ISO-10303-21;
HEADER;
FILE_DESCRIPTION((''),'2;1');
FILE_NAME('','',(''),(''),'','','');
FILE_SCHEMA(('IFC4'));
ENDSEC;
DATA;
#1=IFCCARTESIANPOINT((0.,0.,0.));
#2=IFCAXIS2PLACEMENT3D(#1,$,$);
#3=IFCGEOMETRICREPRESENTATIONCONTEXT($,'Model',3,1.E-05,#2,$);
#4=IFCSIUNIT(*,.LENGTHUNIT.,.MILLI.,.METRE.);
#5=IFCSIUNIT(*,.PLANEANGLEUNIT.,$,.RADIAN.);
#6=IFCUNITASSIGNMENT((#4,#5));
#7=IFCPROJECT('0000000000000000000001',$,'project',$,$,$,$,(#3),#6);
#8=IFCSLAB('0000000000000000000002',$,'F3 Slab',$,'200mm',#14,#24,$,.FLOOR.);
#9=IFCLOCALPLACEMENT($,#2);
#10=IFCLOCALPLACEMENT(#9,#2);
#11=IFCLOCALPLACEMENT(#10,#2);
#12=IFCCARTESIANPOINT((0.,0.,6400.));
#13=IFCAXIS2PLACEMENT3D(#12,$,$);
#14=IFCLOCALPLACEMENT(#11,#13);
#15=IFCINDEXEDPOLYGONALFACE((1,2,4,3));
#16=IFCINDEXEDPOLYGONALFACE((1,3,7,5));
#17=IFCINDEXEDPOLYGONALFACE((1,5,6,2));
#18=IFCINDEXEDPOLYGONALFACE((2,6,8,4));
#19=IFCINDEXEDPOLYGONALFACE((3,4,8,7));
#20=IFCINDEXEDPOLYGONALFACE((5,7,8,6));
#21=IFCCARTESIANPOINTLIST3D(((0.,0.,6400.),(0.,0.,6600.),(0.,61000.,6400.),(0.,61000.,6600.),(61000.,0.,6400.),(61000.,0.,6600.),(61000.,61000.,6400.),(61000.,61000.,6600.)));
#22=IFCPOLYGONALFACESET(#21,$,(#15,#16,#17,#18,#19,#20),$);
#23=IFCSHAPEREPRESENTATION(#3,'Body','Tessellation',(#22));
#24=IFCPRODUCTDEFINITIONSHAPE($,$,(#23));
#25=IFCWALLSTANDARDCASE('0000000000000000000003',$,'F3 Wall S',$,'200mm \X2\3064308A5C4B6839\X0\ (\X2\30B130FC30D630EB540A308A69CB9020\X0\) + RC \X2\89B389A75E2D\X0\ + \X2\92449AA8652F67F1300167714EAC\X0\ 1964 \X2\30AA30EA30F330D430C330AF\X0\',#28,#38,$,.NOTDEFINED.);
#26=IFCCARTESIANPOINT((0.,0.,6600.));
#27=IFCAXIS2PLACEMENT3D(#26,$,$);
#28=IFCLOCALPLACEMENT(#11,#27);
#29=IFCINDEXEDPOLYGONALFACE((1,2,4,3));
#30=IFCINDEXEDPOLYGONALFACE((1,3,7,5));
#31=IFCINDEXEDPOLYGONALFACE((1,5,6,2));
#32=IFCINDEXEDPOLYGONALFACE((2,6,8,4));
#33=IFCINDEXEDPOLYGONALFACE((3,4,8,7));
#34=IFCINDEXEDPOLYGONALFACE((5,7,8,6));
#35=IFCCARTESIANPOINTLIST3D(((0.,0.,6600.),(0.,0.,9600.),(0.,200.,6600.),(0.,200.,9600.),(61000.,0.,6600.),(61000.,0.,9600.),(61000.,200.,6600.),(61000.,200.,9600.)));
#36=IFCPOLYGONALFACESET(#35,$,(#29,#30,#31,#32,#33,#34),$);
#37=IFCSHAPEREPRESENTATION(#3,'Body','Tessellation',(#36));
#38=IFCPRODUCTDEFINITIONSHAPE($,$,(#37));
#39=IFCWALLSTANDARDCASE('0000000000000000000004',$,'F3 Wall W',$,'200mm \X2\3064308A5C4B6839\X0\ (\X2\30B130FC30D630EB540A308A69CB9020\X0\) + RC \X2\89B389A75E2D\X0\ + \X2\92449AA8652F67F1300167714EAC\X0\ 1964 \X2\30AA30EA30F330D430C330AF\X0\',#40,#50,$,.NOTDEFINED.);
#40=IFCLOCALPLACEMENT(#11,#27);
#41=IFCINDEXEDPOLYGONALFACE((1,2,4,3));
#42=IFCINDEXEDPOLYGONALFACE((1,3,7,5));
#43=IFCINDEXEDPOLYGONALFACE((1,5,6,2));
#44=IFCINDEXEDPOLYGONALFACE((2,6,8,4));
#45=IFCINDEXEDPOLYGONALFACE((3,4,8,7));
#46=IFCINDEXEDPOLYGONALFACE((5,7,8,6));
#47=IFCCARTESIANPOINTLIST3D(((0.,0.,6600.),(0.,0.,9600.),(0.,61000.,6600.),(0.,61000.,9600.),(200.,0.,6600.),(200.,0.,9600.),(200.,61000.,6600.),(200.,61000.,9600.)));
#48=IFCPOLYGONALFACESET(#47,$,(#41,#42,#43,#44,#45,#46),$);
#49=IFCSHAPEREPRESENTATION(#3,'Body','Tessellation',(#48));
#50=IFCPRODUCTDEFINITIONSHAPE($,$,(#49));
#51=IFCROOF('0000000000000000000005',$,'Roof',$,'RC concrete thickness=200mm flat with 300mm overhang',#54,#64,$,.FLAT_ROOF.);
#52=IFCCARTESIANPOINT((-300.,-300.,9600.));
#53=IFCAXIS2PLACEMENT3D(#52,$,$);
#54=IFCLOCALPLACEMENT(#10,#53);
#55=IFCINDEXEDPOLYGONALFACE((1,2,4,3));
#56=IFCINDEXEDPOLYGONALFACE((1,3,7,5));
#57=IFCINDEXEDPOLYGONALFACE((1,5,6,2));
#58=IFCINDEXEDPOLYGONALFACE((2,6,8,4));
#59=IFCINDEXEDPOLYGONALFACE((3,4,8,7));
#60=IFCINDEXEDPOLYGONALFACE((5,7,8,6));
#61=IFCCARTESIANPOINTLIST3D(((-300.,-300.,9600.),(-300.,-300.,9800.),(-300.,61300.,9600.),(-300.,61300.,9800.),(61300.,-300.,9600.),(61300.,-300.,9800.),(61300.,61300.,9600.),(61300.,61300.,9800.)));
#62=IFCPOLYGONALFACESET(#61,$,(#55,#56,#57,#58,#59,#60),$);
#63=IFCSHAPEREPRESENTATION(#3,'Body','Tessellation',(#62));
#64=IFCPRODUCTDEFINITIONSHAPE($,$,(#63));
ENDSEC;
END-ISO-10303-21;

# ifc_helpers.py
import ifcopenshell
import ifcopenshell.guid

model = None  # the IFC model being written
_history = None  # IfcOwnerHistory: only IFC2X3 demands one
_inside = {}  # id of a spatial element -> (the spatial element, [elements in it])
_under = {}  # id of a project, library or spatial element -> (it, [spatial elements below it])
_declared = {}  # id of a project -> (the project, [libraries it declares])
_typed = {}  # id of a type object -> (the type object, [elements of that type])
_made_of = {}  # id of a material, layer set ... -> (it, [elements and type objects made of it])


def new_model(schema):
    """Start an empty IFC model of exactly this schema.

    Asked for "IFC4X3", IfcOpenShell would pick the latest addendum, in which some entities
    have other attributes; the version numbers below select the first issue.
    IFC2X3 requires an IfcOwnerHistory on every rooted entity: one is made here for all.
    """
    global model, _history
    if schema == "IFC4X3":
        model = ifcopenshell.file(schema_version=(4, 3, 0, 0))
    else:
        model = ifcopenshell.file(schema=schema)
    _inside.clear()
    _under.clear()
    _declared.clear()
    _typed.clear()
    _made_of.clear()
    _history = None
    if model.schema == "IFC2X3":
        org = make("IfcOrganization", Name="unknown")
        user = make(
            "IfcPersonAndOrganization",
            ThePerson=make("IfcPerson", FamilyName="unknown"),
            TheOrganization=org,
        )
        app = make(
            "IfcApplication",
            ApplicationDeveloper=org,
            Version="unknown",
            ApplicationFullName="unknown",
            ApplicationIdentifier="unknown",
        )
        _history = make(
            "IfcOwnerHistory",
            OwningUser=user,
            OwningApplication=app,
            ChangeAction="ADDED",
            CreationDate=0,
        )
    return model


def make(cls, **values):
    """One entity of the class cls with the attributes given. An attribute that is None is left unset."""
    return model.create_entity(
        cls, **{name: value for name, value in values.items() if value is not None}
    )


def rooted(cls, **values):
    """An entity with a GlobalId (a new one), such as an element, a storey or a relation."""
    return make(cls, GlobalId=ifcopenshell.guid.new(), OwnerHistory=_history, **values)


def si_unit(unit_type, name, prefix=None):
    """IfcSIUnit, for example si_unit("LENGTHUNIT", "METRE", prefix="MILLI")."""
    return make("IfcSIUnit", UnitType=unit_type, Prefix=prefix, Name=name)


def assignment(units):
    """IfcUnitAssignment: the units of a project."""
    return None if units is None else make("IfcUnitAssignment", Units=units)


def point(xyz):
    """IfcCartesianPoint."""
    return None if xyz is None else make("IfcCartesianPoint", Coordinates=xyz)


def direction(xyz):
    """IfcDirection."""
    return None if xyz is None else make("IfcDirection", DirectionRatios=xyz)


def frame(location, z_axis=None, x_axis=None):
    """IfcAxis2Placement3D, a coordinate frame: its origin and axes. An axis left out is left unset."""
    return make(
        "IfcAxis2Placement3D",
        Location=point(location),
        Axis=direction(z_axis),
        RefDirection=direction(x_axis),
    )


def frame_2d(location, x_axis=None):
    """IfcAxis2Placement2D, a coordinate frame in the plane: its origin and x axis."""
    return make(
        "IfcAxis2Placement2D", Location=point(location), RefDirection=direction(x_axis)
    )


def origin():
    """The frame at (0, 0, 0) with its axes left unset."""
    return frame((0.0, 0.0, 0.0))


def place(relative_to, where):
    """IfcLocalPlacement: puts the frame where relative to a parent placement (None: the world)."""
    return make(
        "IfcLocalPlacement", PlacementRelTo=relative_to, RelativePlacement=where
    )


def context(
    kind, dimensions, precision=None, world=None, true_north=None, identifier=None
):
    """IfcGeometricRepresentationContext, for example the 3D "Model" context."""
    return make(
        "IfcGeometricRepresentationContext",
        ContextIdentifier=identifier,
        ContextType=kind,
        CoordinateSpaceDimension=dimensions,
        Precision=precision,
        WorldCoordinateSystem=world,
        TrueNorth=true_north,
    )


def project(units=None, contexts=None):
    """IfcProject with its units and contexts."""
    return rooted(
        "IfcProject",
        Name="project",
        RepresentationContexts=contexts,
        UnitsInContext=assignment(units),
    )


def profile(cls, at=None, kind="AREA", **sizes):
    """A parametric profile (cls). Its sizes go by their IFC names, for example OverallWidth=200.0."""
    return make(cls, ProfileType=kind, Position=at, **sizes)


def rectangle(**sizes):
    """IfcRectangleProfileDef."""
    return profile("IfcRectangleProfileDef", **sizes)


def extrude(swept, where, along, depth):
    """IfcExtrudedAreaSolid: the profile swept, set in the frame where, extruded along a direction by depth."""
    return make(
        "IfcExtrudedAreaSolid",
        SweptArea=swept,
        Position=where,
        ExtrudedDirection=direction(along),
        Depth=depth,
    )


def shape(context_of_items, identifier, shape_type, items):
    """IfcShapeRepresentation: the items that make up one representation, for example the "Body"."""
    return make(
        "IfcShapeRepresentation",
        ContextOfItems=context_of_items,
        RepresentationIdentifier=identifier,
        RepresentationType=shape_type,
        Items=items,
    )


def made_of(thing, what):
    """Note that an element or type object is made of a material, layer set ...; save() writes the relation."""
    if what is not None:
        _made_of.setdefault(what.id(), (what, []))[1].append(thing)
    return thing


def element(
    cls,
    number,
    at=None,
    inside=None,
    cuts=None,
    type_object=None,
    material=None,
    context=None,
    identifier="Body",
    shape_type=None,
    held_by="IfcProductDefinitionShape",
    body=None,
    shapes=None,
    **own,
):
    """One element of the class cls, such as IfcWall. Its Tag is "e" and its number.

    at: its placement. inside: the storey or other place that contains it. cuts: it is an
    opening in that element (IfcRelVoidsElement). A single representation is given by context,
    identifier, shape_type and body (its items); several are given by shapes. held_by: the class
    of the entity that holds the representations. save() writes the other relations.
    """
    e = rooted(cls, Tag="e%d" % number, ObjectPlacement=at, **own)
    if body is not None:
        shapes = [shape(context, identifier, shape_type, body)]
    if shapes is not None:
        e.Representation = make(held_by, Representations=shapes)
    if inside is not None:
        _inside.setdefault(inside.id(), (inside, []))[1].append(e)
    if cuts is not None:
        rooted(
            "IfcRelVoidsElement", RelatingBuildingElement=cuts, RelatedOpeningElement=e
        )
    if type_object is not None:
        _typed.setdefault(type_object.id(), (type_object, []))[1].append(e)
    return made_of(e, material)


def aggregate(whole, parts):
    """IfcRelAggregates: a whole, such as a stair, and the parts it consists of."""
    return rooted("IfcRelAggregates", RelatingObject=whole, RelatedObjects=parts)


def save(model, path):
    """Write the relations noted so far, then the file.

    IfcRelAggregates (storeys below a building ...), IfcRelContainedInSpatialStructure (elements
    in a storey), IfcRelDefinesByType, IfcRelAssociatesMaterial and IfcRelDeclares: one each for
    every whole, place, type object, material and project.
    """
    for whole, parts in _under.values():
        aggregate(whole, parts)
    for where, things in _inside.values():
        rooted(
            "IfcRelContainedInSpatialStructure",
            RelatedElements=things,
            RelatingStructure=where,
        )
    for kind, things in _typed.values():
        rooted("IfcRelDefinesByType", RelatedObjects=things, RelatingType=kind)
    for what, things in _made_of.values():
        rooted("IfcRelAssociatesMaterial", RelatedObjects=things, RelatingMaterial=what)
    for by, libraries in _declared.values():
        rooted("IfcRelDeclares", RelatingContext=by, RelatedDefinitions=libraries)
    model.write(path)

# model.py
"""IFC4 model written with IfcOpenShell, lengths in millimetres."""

from ifc_helpers import new_model, si_unit, frame, frame_2d, origin, place, context, project, rectangle, extrude, element, save


model = new_model("IFC4")

# Units and contexts
model_context = context("Model", 3, precision=1e-05, world=origin())
ifc_project = project(units=[si_unit("LENGTHUNIT", "METRE", prefix="MILLI"), si_unit("PLANEANGLEUNIT", "RADIAN")], contexts=[model_context])

# Slab
placement_1 = place(None, origin())
placement_2 = place(placement_1, origin())
placement_3 = place(placement_2, origin())
slab_placement = place(placement_3, frame((0.0, 0.0, 6400.0)))
element("IfcSlab", 1, at=slab_placement, Name="F3 Slab", ObjectType="200mm", PredefinedType="FLOOR", context=model_context, shape_type="SweptSolid", body=[
    extrude(rectangle(XDim=61000.0, YDim=61000.0, at=frame_2d((30500.0, 30500.0))), frame((0.0, 0.0, 6400.0)), (0.0, 0.0, 1.0), 200.0),
])

# Walls
wall_1_placement = place(placement_3, frame((0.0, 0.0, 6600.0)))
element("IfcWallStandardCase", 2, at=wall_1_placement, Name="F3 Wall S", ObjectType="200mm つり屋根 (ケーブル吊り構造) + RC 観覧席 + 鉄骨支柱、東京 1964 オリンピック", PredefinedType="NOTDEFINED", context=model_context, shape_type="SweptSolid", body=[
    extrude(rectangle(XDim=61000.0, YDim=200.0, at=frame_2d((30500.0, 100.0))), frame((0.0, 0.0, 6600.0)), (0.0, 0.0, 1.0), 3000.0),
])
wall_2_placement = place(placement_3, frame((0.0, 0.0, 6600.0)))
element("IfcWallStandardCase", 3, at=wall_2_placement, Name="F3 Wall W", ObjectType="200mm つり屋根 (ケーブル吊り構造) + RC 観覧席 + 鉄骨支柱、東京 1964 オリンピック", PredefinedType="NOTDEFINED", context=model_context, shape_type="SweptSolid", body=[
    extrude(rectangle(XDim=200.0, YDim=61000.0, at=frame_2d((100.0, 30500.0))), frame((0.0, 0.0, 6600.0)), (0.0, 0.0, 1.0), 3000.0),
])

# Roof
roof_placement = place(placement_2, frame((-300.0, -300.0, 9600.0)))
element("IfcRoof", 4, at=roof_placement, Name="Roof", ObjectType="RC concrete thickness=200mm flat with 300mm overhang", PredefinedType="FLAT_ROOF", context=model_context, shape_type="SweptSolid", body=[
    extrude(rectangle(XDim=61600.0, YDim=61600.0, at=frame_2d((30800.0, 30800.0))), frame((-300.0, -300.0, 9600.0)), (0.0, 0.0, 1.0), 200.0),
])

save(model, "model.ifc")
